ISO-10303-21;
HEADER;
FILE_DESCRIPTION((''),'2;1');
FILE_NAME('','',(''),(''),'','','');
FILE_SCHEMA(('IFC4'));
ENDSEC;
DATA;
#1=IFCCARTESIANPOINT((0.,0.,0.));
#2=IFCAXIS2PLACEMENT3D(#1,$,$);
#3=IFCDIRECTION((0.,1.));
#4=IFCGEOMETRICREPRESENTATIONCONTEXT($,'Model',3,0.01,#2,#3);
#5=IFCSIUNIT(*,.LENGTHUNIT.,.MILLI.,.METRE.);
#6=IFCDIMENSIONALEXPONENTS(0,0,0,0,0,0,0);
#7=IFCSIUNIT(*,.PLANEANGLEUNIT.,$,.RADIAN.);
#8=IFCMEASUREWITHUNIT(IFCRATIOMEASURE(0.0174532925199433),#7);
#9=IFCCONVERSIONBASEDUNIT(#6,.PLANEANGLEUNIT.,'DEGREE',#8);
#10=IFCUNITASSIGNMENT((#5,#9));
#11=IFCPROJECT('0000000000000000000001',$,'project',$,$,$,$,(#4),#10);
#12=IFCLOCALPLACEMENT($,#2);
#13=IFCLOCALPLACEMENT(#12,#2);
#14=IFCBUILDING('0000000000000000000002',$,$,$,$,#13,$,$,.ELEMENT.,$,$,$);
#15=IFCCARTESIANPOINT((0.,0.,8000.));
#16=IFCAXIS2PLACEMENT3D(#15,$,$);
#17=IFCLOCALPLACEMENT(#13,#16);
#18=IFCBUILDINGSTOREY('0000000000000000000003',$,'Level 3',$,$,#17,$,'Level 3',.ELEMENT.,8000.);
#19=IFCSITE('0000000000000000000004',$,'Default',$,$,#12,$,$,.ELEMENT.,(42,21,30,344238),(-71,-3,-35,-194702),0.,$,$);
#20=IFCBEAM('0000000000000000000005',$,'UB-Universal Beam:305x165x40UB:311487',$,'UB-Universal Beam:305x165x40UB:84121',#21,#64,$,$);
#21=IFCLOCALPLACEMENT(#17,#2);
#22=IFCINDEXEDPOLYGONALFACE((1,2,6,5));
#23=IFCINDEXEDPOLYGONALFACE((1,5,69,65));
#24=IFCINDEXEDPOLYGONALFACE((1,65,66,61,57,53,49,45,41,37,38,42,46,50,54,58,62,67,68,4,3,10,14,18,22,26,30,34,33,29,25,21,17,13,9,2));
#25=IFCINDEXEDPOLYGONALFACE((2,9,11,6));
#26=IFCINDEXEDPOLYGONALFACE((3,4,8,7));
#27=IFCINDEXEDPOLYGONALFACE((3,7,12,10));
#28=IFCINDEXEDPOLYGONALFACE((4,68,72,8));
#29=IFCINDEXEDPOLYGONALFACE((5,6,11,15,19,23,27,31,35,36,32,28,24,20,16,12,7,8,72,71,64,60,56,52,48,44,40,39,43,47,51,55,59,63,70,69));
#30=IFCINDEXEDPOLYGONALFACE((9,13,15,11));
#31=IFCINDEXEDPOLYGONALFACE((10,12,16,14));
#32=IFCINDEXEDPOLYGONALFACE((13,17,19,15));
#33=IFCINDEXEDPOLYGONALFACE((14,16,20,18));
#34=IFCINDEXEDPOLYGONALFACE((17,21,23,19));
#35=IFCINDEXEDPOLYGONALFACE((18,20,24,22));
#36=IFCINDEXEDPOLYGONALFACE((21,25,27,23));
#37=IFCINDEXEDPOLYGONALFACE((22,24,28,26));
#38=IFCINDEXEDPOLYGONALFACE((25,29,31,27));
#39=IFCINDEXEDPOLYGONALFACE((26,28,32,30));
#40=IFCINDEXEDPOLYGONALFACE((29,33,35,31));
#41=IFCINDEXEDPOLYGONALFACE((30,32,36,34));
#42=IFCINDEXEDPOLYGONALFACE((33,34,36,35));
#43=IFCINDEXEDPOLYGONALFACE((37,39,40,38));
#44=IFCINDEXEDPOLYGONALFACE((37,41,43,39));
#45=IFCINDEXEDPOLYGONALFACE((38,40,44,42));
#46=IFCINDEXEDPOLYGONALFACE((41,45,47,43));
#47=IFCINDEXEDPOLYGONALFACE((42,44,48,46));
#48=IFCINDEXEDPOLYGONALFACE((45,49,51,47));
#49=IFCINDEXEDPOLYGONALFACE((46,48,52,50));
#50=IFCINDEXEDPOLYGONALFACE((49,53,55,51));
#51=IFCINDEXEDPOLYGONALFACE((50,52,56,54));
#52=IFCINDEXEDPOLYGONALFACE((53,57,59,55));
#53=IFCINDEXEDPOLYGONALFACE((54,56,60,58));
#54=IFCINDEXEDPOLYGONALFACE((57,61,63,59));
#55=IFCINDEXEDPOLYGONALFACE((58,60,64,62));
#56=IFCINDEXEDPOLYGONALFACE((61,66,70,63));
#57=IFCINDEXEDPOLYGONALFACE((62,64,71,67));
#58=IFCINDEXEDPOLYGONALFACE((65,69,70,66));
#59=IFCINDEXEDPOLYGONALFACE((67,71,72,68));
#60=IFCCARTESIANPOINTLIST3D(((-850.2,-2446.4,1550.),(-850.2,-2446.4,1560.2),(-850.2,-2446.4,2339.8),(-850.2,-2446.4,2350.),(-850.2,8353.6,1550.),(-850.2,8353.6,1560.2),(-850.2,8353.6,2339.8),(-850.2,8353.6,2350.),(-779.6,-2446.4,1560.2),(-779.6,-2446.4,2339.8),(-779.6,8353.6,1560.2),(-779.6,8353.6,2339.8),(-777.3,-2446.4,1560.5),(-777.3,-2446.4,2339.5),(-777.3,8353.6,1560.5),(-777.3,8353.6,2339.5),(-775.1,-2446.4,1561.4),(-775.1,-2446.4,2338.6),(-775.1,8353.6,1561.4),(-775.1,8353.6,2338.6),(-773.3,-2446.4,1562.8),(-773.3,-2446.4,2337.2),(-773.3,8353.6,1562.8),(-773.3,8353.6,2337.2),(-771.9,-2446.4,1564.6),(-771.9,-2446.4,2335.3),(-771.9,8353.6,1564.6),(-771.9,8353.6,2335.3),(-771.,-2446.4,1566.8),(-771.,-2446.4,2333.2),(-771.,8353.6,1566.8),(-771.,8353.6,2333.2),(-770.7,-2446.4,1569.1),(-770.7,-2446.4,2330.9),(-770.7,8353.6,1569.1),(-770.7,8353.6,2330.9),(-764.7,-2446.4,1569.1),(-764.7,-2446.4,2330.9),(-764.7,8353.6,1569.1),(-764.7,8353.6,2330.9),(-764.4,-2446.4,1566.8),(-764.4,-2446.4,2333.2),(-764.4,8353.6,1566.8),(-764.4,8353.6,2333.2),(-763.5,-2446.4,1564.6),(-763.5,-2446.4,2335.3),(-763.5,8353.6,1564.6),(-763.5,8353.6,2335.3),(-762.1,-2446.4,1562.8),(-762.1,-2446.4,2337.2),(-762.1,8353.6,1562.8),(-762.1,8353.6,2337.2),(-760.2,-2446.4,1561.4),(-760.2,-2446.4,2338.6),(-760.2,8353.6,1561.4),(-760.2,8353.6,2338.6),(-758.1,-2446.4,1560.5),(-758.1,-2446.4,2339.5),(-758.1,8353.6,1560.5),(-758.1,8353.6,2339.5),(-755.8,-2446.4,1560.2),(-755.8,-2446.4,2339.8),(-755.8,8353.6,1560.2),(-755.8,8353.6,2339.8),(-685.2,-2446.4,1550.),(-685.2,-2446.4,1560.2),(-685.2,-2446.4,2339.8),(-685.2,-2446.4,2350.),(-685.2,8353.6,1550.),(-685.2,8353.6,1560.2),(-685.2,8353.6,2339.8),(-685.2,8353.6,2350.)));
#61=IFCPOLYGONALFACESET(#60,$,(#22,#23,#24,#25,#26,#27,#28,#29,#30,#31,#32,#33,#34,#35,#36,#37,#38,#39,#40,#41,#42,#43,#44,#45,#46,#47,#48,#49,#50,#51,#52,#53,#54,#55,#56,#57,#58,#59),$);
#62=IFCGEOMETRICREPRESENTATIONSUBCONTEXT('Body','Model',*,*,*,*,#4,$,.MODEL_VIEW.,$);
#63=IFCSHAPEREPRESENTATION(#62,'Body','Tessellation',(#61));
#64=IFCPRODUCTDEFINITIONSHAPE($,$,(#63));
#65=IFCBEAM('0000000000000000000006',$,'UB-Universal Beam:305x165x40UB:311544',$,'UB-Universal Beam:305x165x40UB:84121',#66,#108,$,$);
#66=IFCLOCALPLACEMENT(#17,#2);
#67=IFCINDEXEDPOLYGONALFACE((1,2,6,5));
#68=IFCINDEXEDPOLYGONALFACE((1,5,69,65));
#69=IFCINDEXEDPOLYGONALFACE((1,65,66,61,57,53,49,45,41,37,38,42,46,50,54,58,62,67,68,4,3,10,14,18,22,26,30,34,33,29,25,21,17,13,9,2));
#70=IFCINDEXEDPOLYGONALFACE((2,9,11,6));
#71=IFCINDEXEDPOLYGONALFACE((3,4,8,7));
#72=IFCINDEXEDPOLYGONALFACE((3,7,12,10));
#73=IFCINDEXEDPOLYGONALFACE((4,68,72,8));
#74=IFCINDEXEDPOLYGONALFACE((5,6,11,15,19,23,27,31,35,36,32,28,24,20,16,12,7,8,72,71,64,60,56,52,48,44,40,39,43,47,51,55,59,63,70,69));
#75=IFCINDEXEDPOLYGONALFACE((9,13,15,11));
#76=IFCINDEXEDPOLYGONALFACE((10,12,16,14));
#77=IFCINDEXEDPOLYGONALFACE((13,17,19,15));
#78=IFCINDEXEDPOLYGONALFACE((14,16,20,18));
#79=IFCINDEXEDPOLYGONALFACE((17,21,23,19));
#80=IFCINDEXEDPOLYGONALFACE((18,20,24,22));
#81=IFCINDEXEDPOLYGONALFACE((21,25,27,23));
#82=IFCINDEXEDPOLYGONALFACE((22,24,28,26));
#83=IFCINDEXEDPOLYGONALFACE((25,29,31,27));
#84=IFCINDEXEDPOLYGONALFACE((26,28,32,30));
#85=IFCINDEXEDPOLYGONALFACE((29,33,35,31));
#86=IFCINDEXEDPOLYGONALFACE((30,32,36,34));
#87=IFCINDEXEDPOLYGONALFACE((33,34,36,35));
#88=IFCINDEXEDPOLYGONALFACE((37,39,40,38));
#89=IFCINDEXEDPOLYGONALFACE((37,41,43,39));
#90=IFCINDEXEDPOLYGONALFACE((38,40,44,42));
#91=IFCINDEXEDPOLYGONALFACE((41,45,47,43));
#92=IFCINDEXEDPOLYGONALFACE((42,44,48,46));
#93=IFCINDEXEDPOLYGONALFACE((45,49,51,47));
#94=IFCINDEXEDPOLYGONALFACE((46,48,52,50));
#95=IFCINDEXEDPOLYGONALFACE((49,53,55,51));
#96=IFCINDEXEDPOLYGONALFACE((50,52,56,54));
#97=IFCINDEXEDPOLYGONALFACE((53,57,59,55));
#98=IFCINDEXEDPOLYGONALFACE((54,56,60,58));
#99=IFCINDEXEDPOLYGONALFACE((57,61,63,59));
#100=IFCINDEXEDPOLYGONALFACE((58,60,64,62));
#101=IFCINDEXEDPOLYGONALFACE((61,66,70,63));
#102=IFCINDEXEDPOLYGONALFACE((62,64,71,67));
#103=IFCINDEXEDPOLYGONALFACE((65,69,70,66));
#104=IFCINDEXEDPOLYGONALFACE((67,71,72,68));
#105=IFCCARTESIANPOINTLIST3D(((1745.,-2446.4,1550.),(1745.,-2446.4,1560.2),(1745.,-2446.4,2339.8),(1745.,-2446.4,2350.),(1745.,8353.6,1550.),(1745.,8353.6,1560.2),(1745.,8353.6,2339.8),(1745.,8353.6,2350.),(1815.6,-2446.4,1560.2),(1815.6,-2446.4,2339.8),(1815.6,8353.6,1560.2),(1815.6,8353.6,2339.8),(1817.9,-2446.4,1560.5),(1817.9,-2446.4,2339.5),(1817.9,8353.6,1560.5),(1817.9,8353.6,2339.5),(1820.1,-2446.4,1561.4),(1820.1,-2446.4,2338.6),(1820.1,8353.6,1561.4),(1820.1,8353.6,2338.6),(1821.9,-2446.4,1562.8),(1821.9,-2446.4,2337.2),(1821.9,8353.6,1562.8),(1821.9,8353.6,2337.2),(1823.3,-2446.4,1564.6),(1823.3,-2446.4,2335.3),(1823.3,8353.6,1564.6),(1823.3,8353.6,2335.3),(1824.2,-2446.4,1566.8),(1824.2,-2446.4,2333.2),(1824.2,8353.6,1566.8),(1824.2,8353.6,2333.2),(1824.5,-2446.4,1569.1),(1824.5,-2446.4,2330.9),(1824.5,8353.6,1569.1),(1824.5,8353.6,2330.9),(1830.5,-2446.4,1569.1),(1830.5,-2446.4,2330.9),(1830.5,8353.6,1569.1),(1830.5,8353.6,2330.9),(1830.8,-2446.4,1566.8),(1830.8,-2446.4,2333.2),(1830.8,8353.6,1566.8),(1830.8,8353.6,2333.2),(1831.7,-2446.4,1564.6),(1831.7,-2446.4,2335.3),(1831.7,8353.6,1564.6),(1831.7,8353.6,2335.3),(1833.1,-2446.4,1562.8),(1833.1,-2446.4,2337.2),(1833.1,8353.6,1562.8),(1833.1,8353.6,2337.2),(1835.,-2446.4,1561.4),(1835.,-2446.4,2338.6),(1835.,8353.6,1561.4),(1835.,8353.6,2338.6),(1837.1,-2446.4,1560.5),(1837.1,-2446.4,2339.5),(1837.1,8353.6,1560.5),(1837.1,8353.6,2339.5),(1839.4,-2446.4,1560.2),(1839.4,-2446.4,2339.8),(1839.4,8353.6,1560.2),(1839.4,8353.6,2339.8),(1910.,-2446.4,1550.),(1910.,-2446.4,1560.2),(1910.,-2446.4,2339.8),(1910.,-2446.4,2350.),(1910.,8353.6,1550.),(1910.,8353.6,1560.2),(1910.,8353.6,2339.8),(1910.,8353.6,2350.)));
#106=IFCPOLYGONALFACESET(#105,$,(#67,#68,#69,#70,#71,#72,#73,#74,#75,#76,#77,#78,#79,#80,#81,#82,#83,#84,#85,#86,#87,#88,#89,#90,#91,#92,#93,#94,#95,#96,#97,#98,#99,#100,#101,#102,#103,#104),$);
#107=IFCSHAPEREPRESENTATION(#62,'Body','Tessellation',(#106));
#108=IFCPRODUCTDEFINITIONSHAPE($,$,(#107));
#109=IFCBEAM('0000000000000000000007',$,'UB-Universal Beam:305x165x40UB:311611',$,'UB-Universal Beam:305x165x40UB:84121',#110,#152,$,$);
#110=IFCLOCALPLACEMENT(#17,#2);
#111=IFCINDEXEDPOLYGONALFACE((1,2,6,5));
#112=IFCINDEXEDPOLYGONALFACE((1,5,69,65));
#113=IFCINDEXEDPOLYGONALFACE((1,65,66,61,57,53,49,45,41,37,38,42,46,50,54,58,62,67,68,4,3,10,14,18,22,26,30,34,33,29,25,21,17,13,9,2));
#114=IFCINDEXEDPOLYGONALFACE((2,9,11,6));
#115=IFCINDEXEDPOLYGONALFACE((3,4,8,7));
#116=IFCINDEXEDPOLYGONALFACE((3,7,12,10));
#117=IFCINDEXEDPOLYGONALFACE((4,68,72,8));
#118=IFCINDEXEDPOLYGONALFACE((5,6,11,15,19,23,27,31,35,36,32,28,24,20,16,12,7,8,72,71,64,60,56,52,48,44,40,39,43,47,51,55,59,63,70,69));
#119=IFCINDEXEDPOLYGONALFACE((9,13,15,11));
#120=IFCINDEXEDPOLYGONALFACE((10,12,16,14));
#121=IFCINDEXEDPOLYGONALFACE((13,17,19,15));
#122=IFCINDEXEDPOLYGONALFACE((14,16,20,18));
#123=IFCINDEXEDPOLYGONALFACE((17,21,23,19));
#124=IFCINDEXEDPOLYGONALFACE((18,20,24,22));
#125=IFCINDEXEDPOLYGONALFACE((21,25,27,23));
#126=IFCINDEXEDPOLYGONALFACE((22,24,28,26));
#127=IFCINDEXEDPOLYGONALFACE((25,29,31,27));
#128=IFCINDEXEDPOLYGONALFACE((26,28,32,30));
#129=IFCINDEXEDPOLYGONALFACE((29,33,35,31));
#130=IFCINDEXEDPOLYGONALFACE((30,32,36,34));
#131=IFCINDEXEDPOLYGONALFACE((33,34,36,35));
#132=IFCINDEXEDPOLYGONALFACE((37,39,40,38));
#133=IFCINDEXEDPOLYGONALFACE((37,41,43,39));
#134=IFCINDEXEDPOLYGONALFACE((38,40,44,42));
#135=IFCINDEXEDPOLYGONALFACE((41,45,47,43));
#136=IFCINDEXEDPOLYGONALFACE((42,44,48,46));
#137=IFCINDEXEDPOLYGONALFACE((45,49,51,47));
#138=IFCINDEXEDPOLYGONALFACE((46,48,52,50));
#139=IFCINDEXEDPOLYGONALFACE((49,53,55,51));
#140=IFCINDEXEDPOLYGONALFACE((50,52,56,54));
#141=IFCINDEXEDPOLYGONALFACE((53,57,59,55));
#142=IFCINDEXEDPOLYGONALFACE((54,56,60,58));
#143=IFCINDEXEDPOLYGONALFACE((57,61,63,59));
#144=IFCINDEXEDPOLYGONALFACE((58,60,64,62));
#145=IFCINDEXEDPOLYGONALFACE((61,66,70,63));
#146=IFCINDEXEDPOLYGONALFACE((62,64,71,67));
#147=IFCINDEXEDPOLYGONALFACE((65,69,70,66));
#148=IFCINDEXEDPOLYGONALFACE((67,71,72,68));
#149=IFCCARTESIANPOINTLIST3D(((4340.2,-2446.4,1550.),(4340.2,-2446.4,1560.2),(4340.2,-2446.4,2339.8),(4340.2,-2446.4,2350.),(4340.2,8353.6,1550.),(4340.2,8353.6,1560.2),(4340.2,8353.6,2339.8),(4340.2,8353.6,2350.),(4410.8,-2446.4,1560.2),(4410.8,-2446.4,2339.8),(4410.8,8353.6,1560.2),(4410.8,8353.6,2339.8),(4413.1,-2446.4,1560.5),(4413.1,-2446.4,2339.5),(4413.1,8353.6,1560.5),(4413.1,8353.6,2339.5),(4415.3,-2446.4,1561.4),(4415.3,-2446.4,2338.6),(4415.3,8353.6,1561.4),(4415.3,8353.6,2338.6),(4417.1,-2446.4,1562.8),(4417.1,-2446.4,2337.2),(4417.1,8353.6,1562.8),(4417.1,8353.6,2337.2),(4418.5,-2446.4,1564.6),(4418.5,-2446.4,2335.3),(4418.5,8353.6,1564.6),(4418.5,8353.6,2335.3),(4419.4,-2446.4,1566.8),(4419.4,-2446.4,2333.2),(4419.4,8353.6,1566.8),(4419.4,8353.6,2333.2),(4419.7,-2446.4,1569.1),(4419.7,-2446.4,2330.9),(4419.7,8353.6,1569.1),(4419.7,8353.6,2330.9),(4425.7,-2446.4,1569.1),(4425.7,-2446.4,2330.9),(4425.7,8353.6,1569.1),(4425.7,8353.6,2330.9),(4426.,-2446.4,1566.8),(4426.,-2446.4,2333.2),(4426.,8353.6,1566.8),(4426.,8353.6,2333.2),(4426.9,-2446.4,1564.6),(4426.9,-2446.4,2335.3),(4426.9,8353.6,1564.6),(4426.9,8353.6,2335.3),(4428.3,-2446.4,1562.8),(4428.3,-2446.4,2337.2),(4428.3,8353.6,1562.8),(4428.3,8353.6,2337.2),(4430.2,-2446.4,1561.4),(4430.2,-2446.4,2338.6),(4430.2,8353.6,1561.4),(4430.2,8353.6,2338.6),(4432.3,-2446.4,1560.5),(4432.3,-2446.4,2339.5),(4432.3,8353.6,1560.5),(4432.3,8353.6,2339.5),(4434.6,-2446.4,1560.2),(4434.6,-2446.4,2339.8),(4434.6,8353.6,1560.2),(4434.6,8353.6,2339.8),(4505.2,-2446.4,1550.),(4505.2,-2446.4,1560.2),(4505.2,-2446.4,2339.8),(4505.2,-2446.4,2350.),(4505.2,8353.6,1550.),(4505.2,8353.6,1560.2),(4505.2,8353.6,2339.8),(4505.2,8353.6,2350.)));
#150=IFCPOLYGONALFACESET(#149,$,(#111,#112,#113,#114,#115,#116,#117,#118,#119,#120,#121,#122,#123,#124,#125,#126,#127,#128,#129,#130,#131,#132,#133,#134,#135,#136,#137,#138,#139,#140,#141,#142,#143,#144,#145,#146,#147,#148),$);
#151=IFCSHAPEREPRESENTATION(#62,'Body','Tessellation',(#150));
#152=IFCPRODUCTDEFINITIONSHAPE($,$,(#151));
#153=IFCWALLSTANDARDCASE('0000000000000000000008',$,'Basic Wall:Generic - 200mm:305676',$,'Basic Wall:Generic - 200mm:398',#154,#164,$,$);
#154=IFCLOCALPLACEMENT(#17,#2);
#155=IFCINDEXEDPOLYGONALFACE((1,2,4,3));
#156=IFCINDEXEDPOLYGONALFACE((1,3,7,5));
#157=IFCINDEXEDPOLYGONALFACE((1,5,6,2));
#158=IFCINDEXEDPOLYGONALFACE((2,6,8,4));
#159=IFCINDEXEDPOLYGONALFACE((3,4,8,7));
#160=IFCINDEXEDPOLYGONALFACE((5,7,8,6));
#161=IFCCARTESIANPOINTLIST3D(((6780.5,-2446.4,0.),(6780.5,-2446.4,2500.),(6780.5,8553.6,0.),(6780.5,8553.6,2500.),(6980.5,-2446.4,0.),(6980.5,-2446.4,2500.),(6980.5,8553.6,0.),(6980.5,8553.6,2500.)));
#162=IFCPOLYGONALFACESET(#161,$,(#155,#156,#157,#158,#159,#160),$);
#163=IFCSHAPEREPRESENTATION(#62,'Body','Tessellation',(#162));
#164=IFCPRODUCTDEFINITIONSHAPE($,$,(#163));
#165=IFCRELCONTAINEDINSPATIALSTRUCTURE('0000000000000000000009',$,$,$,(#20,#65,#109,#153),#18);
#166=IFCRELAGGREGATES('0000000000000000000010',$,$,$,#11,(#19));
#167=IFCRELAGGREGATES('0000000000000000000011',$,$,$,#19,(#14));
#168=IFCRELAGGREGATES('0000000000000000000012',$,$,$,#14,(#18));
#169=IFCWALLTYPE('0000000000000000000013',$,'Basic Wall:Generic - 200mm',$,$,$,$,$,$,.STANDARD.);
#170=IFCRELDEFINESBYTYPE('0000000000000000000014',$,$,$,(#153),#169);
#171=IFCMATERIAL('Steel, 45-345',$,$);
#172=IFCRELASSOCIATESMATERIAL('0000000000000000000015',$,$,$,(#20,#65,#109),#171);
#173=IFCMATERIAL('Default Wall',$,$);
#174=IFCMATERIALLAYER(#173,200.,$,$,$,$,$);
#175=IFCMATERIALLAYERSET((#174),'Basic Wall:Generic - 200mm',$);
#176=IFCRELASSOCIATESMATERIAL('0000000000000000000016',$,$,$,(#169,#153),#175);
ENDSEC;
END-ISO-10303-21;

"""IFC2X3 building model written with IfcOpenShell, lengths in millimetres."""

from ifc_helpers import new_model, entity, si_unit, converted_unit, direction, frame, frame_2d, origin, place, context, subcontext, project, spatial, rectangle, i_section, extrude, clip, halfspace, material, layer, layer_set, layer_usage, type_object, element, save


model = new_model("IFC2X3")

# Units and contexts
model_context = context("Model", 3, precision=0.01, world=origin(), true_north=direction((0.0, 1.0)))
body_context = subcontext(model_context, "Body", "Model", "MODEL_VIEW")
ifc_project = project(units=[si_unit("LENGTHUNIT", "METRE", prefix="MILLI"), converted_unit("PLANEANGLEUNIT", "DEGREE", entity("IfcRatioMeasure", 0.0174532925199433), si_unit("PLANEANGLEUNIT", "RADIAN"), dimensions=[0, 0, 0, 0, 0, 0, 0])], contexts=[model_context])

# Site, building, storey
site_placement = place(None, origin())
site = spatial("IfcSite", under=ifc_project, at=site_placement, Name="Default", CompositionType="ELEMENT", RefLatitude=(42, 21, 30, 344238), RefLongitude=(-71, -3, -35, -194702), RefElevation=0.0)
building_placement = place(site_placement, origin())
building = spatial("IfcBuilding", under=site, at=building_placement, CompositionType="ELEMENT")
storey_placement = place(building_placement, frame((0.0, 0.0, 8000.0)))
storey = spatial("IfcBuildingStorey", under=building, at=storey_placement, Name="Level 3", LongName="Level 3", CompositionType="ELEMENT", Elevation=8000.0)

# Beams
ifc_material_1 = material(Name="Steel, 45-345")
beam_1_placement = place(storey_placement, frame((-767.7, 8353.6, 2350.0), z_axis=(0.0, 0.0, 1.0), x_axis=(0.0, -1.0, 0.0)))
element("IfcBeam", 1, at=beam_1_placement, inside=storey, material=ifc_material_1, Name="UB-Universal Beam:305x165x40UB:311487", ObjectType="UB-Universal Beam:305x165x40UB:84121", context=body_context, shape_type="SweptSolid", body=[
    extrude(i_section(OverallWidth=165.0, OverallDepth=800.0, WebThickness=6.0, FlangeThickness=10.2, FilletRadius=8.9, at=frame_2d((0.0, 0.0), x_axis=(0.0, 1.0))), frame((0.0, 0.0, -400.0), z_axis=(1.0, 0.0, 0.0), x_axis=(0.0, 0.0, -1.0)), (0.0, 0.0, 1.0), 10800.0),
])
beam_2_placement = place(storey_placement, frame((1827.5, 8353.6, 2350.0), z_axis=(0.0, 0.0, 1.0), x_axis=(0.0, -1.0, 0.0)))
element("IfcBeam", 2, at=beam_2_placement, inside=storey, material=ifc_material_1, Name="UB-Universal Beam:305x165x40UB:311544", ObjectType="UB-Universal Beam:305x165x40UB:84121", context=body_context, shape_type="SweptSolid", body=[
    extrude(i_section(OverallWidth=165.0, OverallDepth=800.0, WebThickness=6.0, FlangeThickness=10.2, FilletRadius=8.9, at=frame_2d((0.0, 0.0), x_axis=(0.0, 1.0))), frame((0.0, 0.0, -400.0), z_axis=(1.0, 0.0, 0.0), x_axis=(0.0, 0.0, -1.0)), (0.0, 0.0, 1.0), 10800.0),
])
beam_3_placement = place(storey_placement, frame((4422.7, 8353.6, 2350.0), z_axis=(0.0, 0.0, 1.0), x_axis=(0.0, -1.0, 0.0)))
element("IfcBeam", 3, at=beam_3_placement, inside=storey, material=ifc_material_1, Name="UB-Universal Beam:305x165x40UB:311611", ObjectType="UB-Universal Beam:305x165x40UB:84121", context=body_context, shape_type="SweptSolid", body=[
    extrude(i_section(OverallWidth=165.0, OverallDepth=800.0, WebThickness=6.0, FlangeThickness=10.2, FilletRadius=8.9, at=frame_2d((0.0, 0.0), x_axis=(0.0, 1.0))), frame((0.0, 0.0, -400.0), z_axis=(1.0, 0.0, 0.0), x_axis=(0.0, 0.0, -1.0)), (0.0, 0.0, 1.0), 10800.0),
])

# Shared definitions
ifc_material_2 = material(Name="Default Wall")
ifc_layer_1 = layer(ifc_material_2, 200.0)
ifc_layer_set_1 = layer_set([ifc_layer_1], Name="Basic Wall:Generic - 200mm")
wall_type = type_object("IfcWallType", Name="Basic Wall:Generic - 200mm", PredefinedType="STANDARD", material=ifc_layer_set_1)

# Wall
ifc_layer_usage_1 = layer_usage(ifc_layer_set_1, "AXIS2", "NEGATIVE", 100.0)
wall_1_placement = place(storey_placement, frame((6880.5, 8553.6, 0.0), z_axis=(0.0, 0.0, 1.0), x_axis=(0.0, -1.0, 0.0)))
element("IfcWallStandardCase", 4, at=wall_1_placement, inside=storey, type_object=wall_type, material=ifc_layer_usage_1, Name="Basic Wall:Generic - 200mm:305676", ObjectType="Basic Wall:Generic - 200mm:398", context=body_context, shape_type="Clipping", body=[
    clip(extrude(rectangle(XDim=11000.0, YDim=200.0, at=frame_2d((5500.0, 0.0), x_axis=(-1.0, 0.0))), origin(), (0.0, 0.0, 1.0), 2500.0), halfspace(frame((0.0, 0.0, -8000.0)), True)),
])

save(model, "model.ifc")
